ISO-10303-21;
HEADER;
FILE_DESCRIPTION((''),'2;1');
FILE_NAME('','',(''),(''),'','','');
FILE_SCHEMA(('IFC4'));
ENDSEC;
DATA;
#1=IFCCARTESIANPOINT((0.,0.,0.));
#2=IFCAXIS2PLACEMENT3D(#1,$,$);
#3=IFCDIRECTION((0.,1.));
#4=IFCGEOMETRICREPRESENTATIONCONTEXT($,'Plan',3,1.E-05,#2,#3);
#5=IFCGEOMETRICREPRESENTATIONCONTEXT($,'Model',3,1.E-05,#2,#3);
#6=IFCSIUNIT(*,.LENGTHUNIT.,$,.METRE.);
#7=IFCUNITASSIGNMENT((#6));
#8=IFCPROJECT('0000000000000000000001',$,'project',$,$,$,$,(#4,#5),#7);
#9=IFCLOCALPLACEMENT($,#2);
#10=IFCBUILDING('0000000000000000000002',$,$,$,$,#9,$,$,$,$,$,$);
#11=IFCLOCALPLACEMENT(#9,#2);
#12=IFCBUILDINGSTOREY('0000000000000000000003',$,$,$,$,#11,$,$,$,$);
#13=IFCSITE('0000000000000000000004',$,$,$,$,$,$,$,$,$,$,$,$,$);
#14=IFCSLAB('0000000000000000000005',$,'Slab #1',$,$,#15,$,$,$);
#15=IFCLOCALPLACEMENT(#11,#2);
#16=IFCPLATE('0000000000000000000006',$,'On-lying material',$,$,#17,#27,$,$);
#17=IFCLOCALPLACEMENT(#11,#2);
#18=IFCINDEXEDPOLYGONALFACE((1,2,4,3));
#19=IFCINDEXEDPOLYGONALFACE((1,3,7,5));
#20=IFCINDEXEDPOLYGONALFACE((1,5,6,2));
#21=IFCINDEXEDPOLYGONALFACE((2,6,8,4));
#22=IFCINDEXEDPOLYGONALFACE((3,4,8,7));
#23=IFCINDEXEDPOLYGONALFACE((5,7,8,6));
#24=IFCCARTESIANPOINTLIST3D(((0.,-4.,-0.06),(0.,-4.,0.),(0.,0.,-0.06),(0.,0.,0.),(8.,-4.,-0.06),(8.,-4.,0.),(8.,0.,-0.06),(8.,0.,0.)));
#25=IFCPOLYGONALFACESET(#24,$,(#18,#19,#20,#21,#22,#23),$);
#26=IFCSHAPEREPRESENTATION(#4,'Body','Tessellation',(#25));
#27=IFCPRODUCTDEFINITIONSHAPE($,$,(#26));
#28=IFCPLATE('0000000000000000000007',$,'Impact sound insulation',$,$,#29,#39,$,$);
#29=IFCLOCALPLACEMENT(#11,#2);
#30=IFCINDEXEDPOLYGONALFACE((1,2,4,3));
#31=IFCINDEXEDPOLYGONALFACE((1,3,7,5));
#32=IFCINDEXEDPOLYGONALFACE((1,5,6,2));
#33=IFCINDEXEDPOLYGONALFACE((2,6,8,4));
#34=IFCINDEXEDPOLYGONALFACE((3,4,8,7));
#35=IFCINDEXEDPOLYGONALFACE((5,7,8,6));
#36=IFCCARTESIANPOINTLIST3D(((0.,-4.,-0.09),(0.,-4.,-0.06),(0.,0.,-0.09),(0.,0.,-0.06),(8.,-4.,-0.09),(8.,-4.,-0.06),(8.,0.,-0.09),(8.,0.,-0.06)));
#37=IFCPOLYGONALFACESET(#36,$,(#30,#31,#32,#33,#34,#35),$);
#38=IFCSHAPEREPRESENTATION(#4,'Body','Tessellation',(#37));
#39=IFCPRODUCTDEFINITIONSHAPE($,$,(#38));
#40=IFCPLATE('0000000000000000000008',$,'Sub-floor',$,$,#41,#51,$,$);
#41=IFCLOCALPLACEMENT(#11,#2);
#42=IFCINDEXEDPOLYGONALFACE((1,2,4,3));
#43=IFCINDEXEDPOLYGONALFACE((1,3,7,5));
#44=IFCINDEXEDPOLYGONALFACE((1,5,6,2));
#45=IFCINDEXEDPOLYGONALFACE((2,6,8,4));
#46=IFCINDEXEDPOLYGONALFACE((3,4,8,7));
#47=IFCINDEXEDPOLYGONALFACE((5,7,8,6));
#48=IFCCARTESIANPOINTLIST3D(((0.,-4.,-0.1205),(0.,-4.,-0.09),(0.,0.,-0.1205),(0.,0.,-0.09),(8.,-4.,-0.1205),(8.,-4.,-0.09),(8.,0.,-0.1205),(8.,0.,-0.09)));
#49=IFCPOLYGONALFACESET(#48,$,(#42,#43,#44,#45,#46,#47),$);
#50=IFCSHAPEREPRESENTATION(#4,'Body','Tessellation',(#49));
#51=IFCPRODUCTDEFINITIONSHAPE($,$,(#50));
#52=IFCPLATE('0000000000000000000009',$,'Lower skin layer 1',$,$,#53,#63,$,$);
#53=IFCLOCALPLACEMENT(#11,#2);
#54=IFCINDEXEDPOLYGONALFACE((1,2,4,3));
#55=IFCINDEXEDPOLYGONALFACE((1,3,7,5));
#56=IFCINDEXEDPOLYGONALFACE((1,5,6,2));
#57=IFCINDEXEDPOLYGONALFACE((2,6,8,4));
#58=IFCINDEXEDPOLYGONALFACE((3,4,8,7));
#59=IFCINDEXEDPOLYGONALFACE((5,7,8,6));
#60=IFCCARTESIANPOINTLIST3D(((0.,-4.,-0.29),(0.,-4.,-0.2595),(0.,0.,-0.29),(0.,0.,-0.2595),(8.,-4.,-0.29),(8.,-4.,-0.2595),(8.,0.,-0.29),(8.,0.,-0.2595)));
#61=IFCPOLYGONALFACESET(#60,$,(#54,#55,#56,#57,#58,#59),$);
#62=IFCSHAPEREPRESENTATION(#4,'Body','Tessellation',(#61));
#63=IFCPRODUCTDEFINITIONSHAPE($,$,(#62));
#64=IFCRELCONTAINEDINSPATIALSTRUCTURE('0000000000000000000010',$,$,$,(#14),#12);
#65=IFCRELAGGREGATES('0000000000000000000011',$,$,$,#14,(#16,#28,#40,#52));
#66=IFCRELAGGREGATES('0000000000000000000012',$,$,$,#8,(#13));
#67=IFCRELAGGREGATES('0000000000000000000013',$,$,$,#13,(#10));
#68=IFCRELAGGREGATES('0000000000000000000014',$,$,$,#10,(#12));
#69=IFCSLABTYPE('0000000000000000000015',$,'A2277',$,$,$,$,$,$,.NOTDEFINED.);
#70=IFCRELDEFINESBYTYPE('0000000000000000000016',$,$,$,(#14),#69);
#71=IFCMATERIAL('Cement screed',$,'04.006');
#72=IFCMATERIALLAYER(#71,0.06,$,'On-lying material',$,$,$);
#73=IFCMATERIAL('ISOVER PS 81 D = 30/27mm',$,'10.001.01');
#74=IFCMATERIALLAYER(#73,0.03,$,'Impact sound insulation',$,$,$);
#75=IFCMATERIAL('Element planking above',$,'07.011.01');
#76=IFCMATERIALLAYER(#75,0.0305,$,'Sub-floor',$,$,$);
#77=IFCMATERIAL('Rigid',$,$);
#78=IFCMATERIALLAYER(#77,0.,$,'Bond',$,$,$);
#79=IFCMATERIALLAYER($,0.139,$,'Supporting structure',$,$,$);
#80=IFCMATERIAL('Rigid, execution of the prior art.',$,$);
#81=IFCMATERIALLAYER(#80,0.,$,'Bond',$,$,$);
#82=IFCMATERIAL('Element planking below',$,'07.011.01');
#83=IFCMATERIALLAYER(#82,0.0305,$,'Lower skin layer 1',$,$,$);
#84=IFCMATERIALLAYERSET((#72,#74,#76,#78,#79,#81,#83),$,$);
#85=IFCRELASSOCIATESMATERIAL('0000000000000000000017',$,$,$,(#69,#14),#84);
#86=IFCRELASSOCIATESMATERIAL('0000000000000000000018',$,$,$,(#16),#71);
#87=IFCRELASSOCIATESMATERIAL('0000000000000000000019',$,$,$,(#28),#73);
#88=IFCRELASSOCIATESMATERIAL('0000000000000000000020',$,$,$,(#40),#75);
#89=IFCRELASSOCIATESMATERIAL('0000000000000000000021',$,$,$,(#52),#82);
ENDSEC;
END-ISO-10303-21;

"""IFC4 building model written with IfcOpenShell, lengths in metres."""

from ifc_helpers import new_model, si_unit, direction, frame, frame_2d, origin, origin_with_axes, place, context, project, spatial, rectangle, extrude, material, layer, layer_set, type_object, element, aggregate, save


model = new_model("IFC4")

# Units and contexts
plan_context = context("Plan", 3, precision=1e-05, world=origin(), true_north=direction((0.0, 1.0)))
model_context = context("Model", 3, precision=1e-05, world=origin(), true_north=direction((0.0, 1.0)))
ifc_project = project(units=[si_unit("LENGTHUNIT", "METRE")], contexts=[plan_context, model_context])

# Site, building, storey
site = spatial("IfcSite", under=ifc_project)
building_placement = place(None, origin())
building = spatial("IfcBuilding", under=site, at=building_placement)
storey_placement = place(building_placement, origin())
storey = spatial("IfcBuildingStorey", under=building, at=storey_placement)

# Slab, plates
ifc_material_1 = material(Name="Cement screed", Category="04.006")
ifc_layer_1 = layer(ifc_material_1, 0.06, Name="On-lying material")
ifc_material_2 = material(Name="ISOVER PS 81 D = 30/27mm", Category="10.001.01")
ifc_layer_2 = layer(ifc_material_2, 0.03, Name="Impact sound insulation")
ifc_material_3 = material(Name="Element planking above", Category="07.011.01")
ifc_layer_3 = layer(ifc_material_3, 0.0305, Name="Sub-floor")
ifc_material_4 = material(Name="Rigid")
ifc_layer_4 = layer(ifc_material_4, 0.0, Name="Bond")
ifc_layer_5 = layer(None, 0.139, Name="Supporting structure")
ifc_material_5 = material(Name="Rigid, execution of the prior art.")
ifc_layer_6 = layer(ifc_material_5, 0.0, Name="Bond")
ifc_material_6 = material(Name="Element planking below", Category="07.011.01")
ifc_layer_7 = layer(ifc_material_6, 0.0305, Name="Lower skin layer 1")
ifc_layer_set = layer_set([ifc_layer_1, ifc_layer_2, ifc_layer_3, ifc_layer_4, ifc_layer_5, ifc_layer_6, ifc_layer_7])
slab_type = type_object("IfcSlabType", Name="A2277", PredefinedType="NOTDEFINED", material=ifc_layer_set)
slab_placement = place(None, frame((0.0, 0.0, 0.0), z_axis=(0.0, 0.0, -1.0), x_axis=(1.0, 0.0, 0.0)))
slab = element("IfcSlab", 1, at=slab_placement, inside=storey, type_object=slab_type, material=ifc_layer_set, Name="Slab #1")
plate_1_placement = place(slab_placement, origin())
plate_1 = element("IfcPlate", 2, at=plate_1_placement, material=ifc_material_1, Name="On-lying material", context=plan_context, shape_type="SweptSolid", body=[
    extrude(rectangle(XDim=8.0, YDim=4.0, at=frame_2d((4.0, 2.0), x_axis=(1.0, 0.0))), origin_with_axes(), (0.0, 0.0, 1.0), 0.06),
])
plate_2_placement = place(slab_placement, origin())
plate_2 = element("IfcPlate", 3, at=plate_2_placement, material=ifc_material_2, Name="Impact sound insulation", context=plan_context, shape_type="SweptSolid", body=[
    extrude(rectangle(XDim=8.0, YDim=4.0, at=frame_2d((4.0, 2.0), x_axis=(1.0, 0.0))), frame((0.0, 0.0, 0.06), z_axis=(0.0, 0.0, 1.0), x_axis=(1.0, 0.0, 0.0)), (0.0, 0.0, 1.0), 0.03),
])
plate_3_placement = place(slab_placement, origin())
plate_3 = element("IfcPlate", 4, at=plate_3_placement, material=ifc_material_3, Name="Sub-floor", context=plan_context, shape_type="SweptSolid", body=[
    extrude(rectangle(XDim=8.0, YDim=4.0, at=frame_2d((4.0, 2.0), x_axis=(1.0, 0.0))), frame((0.0, 0.0, 0.09), z_axis=(0.0, 0.0, 1.0), x_axis=(1.0, 0.0, 0.0)), (0.0, 0.0, 1.0), 0.0305),
])
plate_4_placement = place(slab_placement, origin())
plate_4 = element("IfcPlate", 5, at=plate_4_placement, material=ifc_material_6, Name="Lower skin layer 1", context=plan_context, shape_type="SweptSolid", body=[
    extrude(rectangle(XDim=8.0, YDim=4.0, at=frame_2d((4.0, 2.0), x_axis=(1.0, 0.0))), frame((0.0, 0.0, 0.2595), z_axis=(0.0, 0.0, 1.0), x_axis=(1.0, 0.0, 0.0)), (0.0, 0.0, 1.0), 0.0305),
])
aggregate(slab, [plate_1, plate_2, plate_3, plate_4])

save(model, "model.ifc")
